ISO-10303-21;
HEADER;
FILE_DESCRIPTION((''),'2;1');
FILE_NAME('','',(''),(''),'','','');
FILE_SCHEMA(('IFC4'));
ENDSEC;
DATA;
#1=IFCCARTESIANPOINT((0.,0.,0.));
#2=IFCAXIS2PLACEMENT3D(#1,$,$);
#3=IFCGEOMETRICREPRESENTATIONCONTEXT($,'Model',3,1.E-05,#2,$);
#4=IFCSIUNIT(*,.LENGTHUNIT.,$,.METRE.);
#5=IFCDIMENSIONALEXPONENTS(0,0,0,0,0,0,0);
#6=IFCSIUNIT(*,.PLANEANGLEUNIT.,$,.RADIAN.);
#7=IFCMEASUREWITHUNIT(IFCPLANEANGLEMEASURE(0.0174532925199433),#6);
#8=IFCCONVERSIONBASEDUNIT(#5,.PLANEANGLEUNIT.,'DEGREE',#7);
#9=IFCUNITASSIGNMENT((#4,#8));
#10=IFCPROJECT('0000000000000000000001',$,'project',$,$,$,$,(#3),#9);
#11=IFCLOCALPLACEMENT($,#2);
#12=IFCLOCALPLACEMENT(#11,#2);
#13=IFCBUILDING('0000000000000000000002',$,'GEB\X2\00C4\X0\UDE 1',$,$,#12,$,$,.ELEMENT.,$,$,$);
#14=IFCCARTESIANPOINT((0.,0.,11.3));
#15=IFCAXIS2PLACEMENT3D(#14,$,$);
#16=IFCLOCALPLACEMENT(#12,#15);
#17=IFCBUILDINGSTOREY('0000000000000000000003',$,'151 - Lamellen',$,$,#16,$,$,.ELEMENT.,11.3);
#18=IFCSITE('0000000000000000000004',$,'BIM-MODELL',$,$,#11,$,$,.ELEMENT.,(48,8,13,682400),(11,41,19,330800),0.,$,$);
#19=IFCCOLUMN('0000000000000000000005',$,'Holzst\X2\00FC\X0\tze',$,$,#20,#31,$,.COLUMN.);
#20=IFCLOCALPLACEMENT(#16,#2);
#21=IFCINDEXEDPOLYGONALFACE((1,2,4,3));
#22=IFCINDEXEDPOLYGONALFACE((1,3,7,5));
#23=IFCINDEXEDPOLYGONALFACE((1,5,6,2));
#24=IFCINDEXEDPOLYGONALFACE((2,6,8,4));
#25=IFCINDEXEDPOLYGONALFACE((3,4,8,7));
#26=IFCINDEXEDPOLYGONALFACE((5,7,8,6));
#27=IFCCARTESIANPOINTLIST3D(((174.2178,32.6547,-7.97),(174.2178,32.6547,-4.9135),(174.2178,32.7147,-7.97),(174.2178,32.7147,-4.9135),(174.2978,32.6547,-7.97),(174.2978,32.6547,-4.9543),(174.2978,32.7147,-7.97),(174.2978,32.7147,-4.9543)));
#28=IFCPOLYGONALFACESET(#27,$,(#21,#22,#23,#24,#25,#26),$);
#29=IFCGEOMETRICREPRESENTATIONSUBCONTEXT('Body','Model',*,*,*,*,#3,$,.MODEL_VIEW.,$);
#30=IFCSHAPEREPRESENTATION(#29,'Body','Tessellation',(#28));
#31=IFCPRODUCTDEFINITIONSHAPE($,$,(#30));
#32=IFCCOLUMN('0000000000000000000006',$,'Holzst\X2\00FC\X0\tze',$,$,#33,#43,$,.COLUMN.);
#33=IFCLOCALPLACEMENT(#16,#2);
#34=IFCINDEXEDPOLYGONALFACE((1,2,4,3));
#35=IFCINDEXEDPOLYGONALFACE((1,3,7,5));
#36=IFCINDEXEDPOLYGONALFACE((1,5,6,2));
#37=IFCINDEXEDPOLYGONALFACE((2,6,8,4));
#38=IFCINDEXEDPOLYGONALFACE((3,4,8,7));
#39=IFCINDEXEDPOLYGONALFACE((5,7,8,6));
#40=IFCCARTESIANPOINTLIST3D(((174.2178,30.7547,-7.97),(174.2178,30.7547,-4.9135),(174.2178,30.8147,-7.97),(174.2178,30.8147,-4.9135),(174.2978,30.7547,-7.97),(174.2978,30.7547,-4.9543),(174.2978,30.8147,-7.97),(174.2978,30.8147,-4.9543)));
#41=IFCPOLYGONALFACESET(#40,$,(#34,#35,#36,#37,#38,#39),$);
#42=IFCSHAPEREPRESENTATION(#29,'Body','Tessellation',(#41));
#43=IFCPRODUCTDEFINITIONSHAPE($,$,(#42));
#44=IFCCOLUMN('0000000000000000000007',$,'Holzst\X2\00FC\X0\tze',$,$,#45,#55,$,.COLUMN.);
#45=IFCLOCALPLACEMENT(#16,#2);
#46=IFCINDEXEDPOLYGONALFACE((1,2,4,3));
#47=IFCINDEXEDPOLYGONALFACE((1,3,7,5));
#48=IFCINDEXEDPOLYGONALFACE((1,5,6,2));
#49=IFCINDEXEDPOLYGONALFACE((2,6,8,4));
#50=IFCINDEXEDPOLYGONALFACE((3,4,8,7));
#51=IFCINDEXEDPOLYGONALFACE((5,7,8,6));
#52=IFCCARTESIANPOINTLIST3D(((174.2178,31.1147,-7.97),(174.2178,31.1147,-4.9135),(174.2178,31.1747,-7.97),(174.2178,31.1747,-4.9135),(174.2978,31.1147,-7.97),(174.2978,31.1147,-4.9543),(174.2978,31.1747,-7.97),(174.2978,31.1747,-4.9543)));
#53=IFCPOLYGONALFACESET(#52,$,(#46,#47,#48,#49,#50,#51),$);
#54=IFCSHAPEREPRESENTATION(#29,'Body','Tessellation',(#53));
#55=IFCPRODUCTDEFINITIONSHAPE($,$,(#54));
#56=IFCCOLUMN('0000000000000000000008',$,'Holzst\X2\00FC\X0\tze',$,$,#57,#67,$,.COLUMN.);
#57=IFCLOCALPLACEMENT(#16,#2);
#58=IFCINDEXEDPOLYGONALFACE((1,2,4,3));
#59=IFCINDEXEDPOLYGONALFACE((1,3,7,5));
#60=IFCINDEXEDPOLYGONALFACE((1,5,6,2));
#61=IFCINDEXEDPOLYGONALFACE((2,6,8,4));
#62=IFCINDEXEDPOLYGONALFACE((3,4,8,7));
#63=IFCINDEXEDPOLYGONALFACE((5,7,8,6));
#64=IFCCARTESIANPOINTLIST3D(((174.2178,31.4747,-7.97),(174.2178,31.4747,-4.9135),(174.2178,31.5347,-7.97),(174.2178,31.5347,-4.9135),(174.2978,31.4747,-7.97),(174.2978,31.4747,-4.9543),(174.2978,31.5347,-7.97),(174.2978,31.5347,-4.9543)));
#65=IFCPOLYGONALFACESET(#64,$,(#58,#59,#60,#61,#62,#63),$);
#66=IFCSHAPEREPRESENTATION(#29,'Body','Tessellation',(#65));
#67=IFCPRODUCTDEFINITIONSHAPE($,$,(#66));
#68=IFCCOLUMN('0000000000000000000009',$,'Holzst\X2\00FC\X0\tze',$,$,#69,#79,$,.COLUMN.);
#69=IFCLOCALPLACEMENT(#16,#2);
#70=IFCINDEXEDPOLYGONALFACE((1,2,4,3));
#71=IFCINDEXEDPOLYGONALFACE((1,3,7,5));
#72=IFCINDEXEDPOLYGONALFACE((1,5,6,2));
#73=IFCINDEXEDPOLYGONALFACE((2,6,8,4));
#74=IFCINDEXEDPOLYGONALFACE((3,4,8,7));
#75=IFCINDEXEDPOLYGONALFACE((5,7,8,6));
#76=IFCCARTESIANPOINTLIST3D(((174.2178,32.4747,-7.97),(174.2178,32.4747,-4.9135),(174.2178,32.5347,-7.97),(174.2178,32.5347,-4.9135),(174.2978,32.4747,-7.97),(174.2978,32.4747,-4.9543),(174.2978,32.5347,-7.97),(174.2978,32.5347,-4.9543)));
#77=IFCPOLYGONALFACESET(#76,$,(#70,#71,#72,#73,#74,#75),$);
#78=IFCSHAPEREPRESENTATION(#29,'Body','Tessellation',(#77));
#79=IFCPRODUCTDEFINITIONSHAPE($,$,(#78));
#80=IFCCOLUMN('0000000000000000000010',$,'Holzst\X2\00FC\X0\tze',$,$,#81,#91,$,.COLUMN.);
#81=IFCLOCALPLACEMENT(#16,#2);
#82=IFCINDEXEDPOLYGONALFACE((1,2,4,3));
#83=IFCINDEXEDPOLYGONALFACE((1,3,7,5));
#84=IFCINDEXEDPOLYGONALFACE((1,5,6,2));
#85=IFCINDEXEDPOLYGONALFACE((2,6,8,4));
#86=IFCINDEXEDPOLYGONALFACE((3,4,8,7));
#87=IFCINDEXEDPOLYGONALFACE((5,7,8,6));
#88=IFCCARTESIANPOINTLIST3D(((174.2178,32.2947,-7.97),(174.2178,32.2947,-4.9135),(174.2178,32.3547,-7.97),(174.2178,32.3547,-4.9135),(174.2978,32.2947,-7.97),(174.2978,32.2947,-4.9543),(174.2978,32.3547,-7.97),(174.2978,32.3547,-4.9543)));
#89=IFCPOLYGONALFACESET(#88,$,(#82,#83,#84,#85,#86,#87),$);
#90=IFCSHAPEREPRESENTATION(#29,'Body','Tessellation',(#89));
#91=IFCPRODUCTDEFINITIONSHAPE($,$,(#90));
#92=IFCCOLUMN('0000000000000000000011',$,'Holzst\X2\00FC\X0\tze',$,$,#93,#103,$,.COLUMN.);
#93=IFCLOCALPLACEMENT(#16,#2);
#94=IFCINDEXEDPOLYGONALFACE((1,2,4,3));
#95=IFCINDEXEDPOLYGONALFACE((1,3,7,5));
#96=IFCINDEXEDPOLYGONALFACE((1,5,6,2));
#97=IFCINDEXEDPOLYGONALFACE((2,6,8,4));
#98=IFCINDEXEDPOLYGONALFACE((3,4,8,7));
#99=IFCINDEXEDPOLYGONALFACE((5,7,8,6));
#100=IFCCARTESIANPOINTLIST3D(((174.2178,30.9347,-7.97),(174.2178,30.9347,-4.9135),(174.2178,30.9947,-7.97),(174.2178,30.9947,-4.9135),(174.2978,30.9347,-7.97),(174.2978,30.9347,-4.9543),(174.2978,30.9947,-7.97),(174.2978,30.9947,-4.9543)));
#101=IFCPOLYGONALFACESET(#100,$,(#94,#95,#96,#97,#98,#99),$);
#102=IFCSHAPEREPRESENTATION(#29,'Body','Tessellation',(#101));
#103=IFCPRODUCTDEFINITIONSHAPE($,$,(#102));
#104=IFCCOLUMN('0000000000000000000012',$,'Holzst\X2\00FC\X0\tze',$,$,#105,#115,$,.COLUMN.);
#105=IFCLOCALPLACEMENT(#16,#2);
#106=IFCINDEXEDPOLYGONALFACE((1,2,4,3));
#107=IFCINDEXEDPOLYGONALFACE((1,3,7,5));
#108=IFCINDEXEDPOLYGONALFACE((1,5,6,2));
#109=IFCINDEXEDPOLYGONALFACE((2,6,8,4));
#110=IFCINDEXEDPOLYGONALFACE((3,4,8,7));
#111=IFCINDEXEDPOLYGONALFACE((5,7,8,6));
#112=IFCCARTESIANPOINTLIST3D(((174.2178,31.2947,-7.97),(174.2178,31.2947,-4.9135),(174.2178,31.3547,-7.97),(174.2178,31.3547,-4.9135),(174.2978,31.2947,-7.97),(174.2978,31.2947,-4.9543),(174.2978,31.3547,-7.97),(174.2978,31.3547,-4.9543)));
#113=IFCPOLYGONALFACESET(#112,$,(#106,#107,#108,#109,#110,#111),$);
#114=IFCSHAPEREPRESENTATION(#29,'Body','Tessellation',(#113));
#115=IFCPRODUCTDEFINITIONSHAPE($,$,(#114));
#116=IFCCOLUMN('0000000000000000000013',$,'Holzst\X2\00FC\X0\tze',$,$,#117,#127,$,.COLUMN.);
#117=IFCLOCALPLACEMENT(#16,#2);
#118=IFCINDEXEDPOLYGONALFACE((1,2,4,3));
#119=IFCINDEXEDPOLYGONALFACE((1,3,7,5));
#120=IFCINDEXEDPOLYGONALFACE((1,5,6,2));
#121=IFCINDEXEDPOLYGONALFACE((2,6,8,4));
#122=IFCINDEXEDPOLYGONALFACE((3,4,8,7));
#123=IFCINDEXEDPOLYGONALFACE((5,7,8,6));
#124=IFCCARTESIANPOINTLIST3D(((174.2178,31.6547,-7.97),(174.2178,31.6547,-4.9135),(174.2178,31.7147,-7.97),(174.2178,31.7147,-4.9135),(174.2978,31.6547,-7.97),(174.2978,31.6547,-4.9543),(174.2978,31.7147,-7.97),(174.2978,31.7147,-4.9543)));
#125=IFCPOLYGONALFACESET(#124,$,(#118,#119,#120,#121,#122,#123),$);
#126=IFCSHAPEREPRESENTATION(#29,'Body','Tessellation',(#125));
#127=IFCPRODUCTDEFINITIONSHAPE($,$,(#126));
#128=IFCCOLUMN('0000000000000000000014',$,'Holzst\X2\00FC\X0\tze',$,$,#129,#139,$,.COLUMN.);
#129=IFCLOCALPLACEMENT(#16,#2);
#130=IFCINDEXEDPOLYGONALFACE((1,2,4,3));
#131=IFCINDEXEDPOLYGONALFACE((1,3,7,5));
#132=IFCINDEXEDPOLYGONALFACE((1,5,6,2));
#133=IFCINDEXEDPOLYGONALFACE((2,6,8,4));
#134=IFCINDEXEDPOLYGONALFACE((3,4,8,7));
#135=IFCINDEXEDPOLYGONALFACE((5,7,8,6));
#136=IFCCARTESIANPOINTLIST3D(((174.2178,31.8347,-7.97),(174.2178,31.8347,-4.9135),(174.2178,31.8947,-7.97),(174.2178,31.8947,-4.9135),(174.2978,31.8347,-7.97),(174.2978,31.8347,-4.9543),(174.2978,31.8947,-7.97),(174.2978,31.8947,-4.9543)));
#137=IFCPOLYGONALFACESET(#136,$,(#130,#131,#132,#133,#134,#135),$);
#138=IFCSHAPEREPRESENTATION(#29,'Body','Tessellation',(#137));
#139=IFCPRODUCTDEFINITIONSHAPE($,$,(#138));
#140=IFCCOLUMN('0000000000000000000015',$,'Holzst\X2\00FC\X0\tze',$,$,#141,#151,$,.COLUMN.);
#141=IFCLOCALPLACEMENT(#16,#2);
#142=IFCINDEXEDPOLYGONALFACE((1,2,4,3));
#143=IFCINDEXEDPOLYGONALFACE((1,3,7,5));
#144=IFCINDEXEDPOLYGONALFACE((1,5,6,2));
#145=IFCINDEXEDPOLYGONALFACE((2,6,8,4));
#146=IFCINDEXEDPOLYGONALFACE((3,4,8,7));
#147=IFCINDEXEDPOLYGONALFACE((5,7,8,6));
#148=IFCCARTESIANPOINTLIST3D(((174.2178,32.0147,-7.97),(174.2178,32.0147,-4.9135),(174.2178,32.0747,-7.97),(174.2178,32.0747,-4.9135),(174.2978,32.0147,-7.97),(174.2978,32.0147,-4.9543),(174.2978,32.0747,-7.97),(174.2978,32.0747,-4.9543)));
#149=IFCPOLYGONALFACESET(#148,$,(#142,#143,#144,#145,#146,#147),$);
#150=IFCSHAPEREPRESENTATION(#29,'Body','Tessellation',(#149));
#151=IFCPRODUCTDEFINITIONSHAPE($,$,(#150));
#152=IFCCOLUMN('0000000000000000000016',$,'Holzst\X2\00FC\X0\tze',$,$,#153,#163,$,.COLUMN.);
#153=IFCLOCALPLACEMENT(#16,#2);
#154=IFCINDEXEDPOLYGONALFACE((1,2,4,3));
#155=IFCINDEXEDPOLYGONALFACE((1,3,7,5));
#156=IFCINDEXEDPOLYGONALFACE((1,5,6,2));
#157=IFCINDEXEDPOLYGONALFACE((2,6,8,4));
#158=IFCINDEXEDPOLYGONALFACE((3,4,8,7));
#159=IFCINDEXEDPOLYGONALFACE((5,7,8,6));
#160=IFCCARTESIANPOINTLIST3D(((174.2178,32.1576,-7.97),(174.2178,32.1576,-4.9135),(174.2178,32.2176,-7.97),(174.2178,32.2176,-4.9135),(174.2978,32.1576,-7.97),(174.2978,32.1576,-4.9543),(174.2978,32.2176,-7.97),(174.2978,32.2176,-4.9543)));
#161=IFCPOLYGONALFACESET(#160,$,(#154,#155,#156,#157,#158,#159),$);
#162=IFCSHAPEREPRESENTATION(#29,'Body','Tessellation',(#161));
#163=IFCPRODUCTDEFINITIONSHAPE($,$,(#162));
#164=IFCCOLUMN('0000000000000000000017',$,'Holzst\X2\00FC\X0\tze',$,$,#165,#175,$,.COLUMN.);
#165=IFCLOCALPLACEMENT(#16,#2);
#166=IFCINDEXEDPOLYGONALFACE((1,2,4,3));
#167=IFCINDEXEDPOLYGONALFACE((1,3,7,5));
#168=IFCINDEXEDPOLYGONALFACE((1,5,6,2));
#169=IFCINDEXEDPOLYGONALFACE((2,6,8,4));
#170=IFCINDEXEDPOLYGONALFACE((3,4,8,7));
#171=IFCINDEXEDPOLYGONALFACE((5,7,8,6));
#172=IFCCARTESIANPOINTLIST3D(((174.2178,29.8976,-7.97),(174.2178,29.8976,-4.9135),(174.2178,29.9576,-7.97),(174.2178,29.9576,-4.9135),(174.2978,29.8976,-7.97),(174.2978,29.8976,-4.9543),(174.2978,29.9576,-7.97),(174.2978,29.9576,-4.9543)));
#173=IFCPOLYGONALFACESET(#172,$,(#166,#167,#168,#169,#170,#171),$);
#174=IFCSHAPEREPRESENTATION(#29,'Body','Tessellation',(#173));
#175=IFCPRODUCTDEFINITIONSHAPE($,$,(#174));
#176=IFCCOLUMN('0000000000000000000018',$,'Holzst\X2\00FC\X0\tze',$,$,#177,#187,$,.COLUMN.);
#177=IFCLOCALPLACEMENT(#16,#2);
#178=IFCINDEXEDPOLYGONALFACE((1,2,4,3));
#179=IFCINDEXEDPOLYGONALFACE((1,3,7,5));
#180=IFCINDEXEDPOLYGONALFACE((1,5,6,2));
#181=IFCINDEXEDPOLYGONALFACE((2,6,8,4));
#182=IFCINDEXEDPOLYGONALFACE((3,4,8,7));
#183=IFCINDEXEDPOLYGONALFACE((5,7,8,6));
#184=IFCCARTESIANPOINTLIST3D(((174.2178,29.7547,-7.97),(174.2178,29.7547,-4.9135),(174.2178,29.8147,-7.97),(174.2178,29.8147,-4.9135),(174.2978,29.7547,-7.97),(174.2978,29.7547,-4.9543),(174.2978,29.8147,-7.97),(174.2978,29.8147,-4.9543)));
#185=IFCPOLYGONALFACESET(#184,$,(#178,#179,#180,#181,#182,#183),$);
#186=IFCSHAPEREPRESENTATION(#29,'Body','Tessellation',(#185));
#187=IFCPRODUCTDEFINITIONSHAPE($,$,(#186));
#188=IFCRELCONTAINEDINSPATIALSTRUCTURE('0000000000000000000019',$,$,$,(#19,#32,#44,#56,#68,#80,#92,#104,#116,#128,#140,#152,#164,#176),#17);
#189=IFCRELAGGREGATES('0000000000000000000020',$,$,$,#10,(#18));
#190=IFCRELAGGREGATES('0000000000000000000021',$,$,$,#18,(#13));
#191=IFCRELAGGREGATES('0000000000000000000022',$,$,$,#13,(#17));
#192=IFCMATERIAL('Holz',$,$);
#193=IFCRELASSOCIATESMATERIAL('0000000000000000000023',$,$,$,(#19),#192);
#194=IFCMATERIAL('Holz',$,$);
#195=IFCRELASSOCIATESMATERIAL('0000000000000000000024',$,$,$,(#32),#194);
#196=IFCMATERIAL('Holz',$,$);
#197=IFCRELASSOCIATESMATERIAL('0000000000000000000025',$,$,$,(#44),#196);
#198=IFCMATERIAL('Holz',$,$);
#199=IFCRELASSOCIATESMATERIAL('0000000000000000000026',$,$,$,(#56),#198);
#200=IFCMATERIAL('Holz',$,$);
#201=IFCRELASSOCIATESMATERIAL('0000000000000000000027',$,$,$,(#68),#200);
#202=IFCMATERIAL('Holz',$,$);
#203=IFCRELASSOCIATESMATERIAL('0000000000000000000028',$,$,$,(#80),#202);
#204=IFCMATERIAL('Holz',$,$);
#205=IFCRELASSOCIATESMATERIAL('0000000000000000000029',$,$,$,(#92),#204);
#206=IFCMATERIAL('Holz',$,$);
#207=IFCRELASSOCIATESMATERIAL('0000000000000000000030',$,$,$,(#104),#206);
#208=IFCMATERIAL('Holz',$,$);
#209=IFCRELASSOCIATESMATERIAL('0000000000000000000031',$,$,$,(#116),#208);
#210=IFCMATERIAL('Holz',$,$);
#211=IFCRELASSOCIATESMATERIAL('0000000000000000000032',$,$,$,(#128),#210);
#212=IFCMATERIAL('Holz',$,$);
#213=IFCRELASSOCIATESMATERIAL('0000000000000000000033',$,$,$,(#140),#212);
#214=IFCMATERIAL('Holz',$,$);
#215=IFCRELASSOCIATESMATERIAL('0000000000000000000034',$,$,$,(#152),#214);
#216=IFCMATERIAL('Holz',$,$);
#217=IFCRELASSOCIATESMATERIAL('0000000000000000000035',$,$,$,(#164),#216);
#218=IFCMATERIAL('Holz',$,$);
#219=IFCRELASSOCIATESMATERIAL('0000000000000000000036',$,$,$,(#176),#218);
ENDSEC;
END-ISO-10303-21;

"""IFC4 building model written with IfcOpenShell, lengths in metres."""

from ifc_helpers import new_model, entity, si_unit, converted_unit, frame, frame_2d, origin, origin_with_axes, place, context, subcontext, project, spatial, rectangle, extrude, clip, halfspace, material, element, save


model = new_model("IFC4")

# Units and contexts
model_context = context("Model", 3, precision=1e-05, world=origin())
body_context = subcontext(model_context, "Body", "Model", "MODEL_VIEW")
ifc_project = project(units=[si_unit("LENGTHUNIT", "METRE"), converted_unit("PLANEANGLEUNIT", "DEGREE", entity("IfcPlaneAngleMeasure", 0.0174532925199433), si_unit("PLANEANGLEUNIT", "RADIAN"), dimensions=[0, 0, 0, 0, 0, 0, 0])], contexts=[model_context])

# Site, building, storey
site_placement = place(None, origin())
site = spatial("IfcSite", under=ifc_project, at=site_placement, Name="BIM-MODELL", CompositionType="ELEMENT", RefLatitude=(48, 8, 13, 682400), RefLongitude=(11, 41, 19, 330800), RefElevation=0.0)
building_placement = place(site_placement, origin())
building = spatial("IfcBuilding", under=site, at=building_placement, Name="GEBÄUDE 1", CompositionType="ELEMENT")
storey_placement = place(building_placement, frame((0.0, 0.0, 11.3)))
storey = spatial("IfcBuildingStorey", under=building, at=storey_placement, Name="151 - Lamellen", CompositionType="ELEMENT", Elevation=11.3)

# Columns
ifc_material_1 = material(Name="Holz")
column_1_placement = place(storey_placement, frame((174.2978, 32.6547, -7.97)))
element("IfcColumn", 1, at=column_1_placement, inside=storey, material=ifc_material_1, Name="Holzstütze", PredefinedType="COLUMN", context=body_context, shape_type="Clipping", body=[
    clip(extrude(rectangle(XDim=0.06, YDim=0.08, at=frame_2d((-0.04, 0.03), x_axis=(0.0, 1.0))), origin_with_axes(), (0.0, 0.0, 1.0), 3.0565), halfspace(frame((-0.04, 0.03, 3.0361), z_axis=(-0.45399, 0.0, -0.891007), x_axis=(0.891007, 0.0, -0.45399)), True)),
])
ifc_material_2 = material(Name="Holz")
column_2_placement = place(storey_placement, frame((174.2978, 30.7547, -7.97)))
element("IfcColumn", 2, at=column_2_placement, inside=storey, material=ifc_material_2, Name="Holzstütze", PredefinedType="COLUMN", context=body_context, shape_type="Clipping", body=[
    clip(extrude(rectangle(XDim=0.06, YDim=0.08, at=frame_2d((-0.04, 0.03), x_axis=(0.0, 1.0))), origin_with_axes(), (0.0, 0.0, 1.0), 3.0565), halfspace(frame((-0.04, 0.03, 3.0361), z_axis=(-0.45399, 0.0, -0.891007), x_axis=(0.891007, 0.0, -0.45399)), True)),
])
ifc_material_3 = material(Name="Holz")
column_3_placement = place(storey_placement, frame((174.2978, 31.1147, -7.97)))
element("IfcColumn", 3, at=column_3_placement, inside=storey, material=ifc_material_3, Name="Holzstütze", PredefinedType="COLUMN", context=body_context, shape_type="Clipping", body=[
    clip(extrude(rectangle(XDim=0.06, YDim=0.08, at=frame_2d((-0.04, 0.03), x_axis=(0.0, 1.0))), origin_with_axes(), (0.0, 0.0, 1.0), 3.0565), halfspace(frame((-0.04, 0.03, 3.0361), z_axis=(-0.45399, 0.0, -0.891007), x_axis=(0.891007, 0.0, -0.45399)), True)),
])
ifc_material_4 = material(Name="Holz")
column_4_placement = place(storey_placement, frame((174.2978, 31.4747, -7.97)))
element("IfcColumn", 4, at=column_4_placement, inside=storey, material=ifc_material_4, Name="Holzstütze", PredefinedType="COLUMN", context=body_context, shape_type="Clipping", body=[
    clip(extrude(rectangle(XDim=0.06, YDim=0.08, at=frame_2d((-0.04, 0.03), x_axis=(0.0, 1.0))), origin_with_axes(), (0.0, 0.0, 1.0), 3.0565), halfspace(frame((-0.04, 0.03, 3.0361), z_axis=(-0.45399, 0.0, -0.891007), x_axis=(0.891007, 0.0, -0.45399)), True)),
])
ifc_material_5 = material(Name="Holz")
column_5_placement = place(storey_placement, frame((174.2978, 32.4747, -7.97)))
element("IfcColumn", 5, at=column_5_placement, inside=storey, material=ifc_material_5, Name="Holzstütze", PredefinedType="COLUMN", context=body_context, shape_type="Clipping", body=[
    clip(extrude(rectangle(XDim=0.06, YDim=0.08, at=frame_2d((-0.04, 0.03), x_axis=(0.0, 1.0))), origin_with_axes(), (0.0, 0.0, 1.0), 3.0565), halfspace(frame((-0.04, 0.03, 3.0361), z_axis=(-0.45399, 0.0, -0.891007), x_axis=(0.891007, 0.0, -0.45399)), True)),
])
ifc_material_6 = material(Name="Holz")
column_6_placement = place(storey_placement, frame((174.2978, 32.2947, -7.97)))
element("IfcColumn", 6, at=column_6_placement, inside=storey, material=ifc_material_6, Name="Holzstütze", PredefinedType="COLUMN", context=body_context, shape_type="Clipping", body=[
    clip(extrude(rectangle(XDim=0.06, YDim=0.08, at=frame_2d((-0.04, 0.03), x_axis=(0.0, 1.0))), origin_with_axes(), (0.0, 0.0, 1.0), 3.0565), halfspace(frame((-0.04, 0.03, 3.0361), z_axis=(-0.45399, 0.0, -0.891007), x_axis=(0.891007, 0.0, -0.45399)), True)),
])
ifc_material_7 = material(Name="Holz")
column_7_placement = place(storey_placement, frame((174.2978, 30.9347, -7.97)))
element("IfcColumn", 7, at=column_7_placement, inside=storey, material=ifc_material_7, Name="Holzstütze", PredefinedType="COLUMN", context=body_context, shape_type="Clipping", body=[
    clip(extrude(rectangle(XDim=0.06, YDim=0.08, at=frame_2d((-0.04, 0.03), x_axis=(0.0, 1.0))), origin_with_axes(), (0.0, 0.0, 1.0), 3.0565), halfspace(frame((-0.04, 0.03, 3.0361), z_axis=(-0.45399, 0.0, -0.891007), x_axis=(0.891007, 0.0, -0.45399)), True)),
])
ifc_material_8 = material(Name="Holz")
column_8_placement = place(storey_placement, frame((174.2978, 31.2947, -7.97)))
element("IfcColumn", 8, at=column_8_placement, inside=storey, material=ifc_material_8, Name="Holzstütze", PredefinedType="COLUMN", context=body_context, shape_type="Clipping", body=[
    clip(extrude(rectangle(XDim=0.06, YDim=0.08, at=frame_2d((-0.04, 0.03), x_axis=(0.0, 1.0))), origin_with_axes(), (0.0, 0.0, 1.0), 3.0565), halfspace(frame((-0.04, 0.03, 3.0361), z_axis=(-0.45399, 0.0, -0.891007), x_axis=(0.891007, 0.0, -0.45399)), True)),
])
ifc_material_9 = material(Name="Holz")
column_9_placement = place(storey_placement, frame((174.2978, 31.6547, -7.97)))
element("IfcColumn", 9, at=column_9_placement, inside=storey, material=ifc_material_9, Name="Holzstütze", PredefinedType="COLUMN", context=body_context, shape_type="Clipping", body=[
    clip(extrude(rectangle(XDim=0.06, YDim=0.08, at=frame_2d((-0.04, 0.03), x_axis=(0.0, 1.0))), origin_with_axes(), (0.0, 0.0, 1.0), 3.0565), halfspace(frame((-0.04, 0.03, 3.0361), z_axis=(-0.45399, 0.0, -0.891007), x_axis=(0.891007, 0.0, -0.45399)), True)),
])
ifc_material_10 = material(Name="Holz")
column_10_placement = place(storey_placement, frame((174.2978, 31.8347, -7.97)))
element("IfcColumn", 10, at=column_10_placement, inside=storey, material=ifc_material_10, Name="Holzstütze", PredefinedType="COLUMN", context=body_context, shape_type="Clipping", body=[
    clip(extrude(rectangle(XDim=0.06, YDim=0.08, at=frame_2d((-0.04, 0.03), x_axis=(0.0, 1.0))), origin_with_axes(), (0.0, 0.0, 1.0), 3.0565), halfspace(frame((-0.04, 0.03, 3.0361), z_axis=(-0.45399, 0.0, -0.891007), x_axis=(0.891007, 0.0, -0.45399)), True)),
])
ifc_material_11 = material(Name="Holz")
column_11_placement = place(storey_placement, frame((174.2978, 32.0147, -7.97)))
element("IfcColumn", 11, at=column_11_placement, inside=storey, material=ifc_material_11, Name="Holzstütze", PredefinedType="COLUMN", context=body_context, shape_type="Clipping", body=[
    clip(extrude(rectangle(XDim=0.06, YDim=0.08, at=frame_2d((-0.04, 0.03), x_axis=(0.0, 1.0))), origin_with_axes(), (0.0, 0.0, 1.0), 3.0565), halfspace(frame((-0.04, 0.03, 3.0361), z_axis=(-0.45399, 0.0, -0.891007), x_axis=(0.891007, 0.0, -0.45399)), True)),
])
ifc_material_12 = material(Name="Holz")
column_12_placement = place(storey_placement, frame((174.2978, 32.1576, -7.97)))
element("IfcColumn", 12, at=column_12_placement, inside=storey, material=ifc_material_12, Name="Holzstütze", PredefinedType="COLUMN", context=body_context, shape_type="Clipping", body=[
    clip(extrude(rectangle(XDim=0.06, YDim=0.08, at=frame_2d((-0.04, 0.03), x_axis=(0.0, 1.0))), origin_with_axes(), (0.0, 0.0, 1.0), 3.0565), halfspace(frame((-0.04, 0.03, 3.0361), z_axis=(-0.45399, 0.0, -0.891007), x_axis=(0.891007, 0.0, -0.45399)), True)),
])
ifc_material_13 = material(Name="Holz")
column_13_placement = place(storey_placement, frame((174.2978, 29.8976, -7.97)))
element("IfcColumn", 13, at=column_13_placement, inside=storey, material=ifc_material_13, Name="Holzstütze", PredefinedType="COLUMN", context=body_context, shape_type="Clipping", body=[
    clip(extrude(rectangle(XDim=0.06, YDim=0.08, at=frame_2d((-0.04, 0.03), x_axis=(0.0, 1.0))), origin_with_axes(), (0.0, 0.0, 1.0), 3.0565), halfspace(frame((-0.04, 0.03, 3.0361), z_axis=(-0.45399, 0.0, -0.891007), x_axis=(0.891007, 0.0, -0.45399)), True)),
])
ifc_material_14 = material(Name="Holz")
column_14_placement = place(storey_placement, frame((174.2978, 29.7547, -7.97)))
element("IfcColumn", 14, at=column_14_placement, inside=storey, material=ifc_material_14, Name="Holzstütze", PredefinedType="COLUMN", context=body_context, shape_type="Clipping", body=[
    clip(extrude(rectangle(XDim=0.06, YDim=0.08, at=frame_2d((-0.04, 0.03), x_axis=(0.0, 1.0))), origin_with_axes(), (0.0, 0.0, 1.0), 3.0565), halfspace(frame((-0.04, 0.03, 3.0361), z_axis=(-0.45399, 0.0, -0.891007), x_axis=(0.891007, 0.0, -0.45399)), True)),
])

save(model, "model.ifc")
